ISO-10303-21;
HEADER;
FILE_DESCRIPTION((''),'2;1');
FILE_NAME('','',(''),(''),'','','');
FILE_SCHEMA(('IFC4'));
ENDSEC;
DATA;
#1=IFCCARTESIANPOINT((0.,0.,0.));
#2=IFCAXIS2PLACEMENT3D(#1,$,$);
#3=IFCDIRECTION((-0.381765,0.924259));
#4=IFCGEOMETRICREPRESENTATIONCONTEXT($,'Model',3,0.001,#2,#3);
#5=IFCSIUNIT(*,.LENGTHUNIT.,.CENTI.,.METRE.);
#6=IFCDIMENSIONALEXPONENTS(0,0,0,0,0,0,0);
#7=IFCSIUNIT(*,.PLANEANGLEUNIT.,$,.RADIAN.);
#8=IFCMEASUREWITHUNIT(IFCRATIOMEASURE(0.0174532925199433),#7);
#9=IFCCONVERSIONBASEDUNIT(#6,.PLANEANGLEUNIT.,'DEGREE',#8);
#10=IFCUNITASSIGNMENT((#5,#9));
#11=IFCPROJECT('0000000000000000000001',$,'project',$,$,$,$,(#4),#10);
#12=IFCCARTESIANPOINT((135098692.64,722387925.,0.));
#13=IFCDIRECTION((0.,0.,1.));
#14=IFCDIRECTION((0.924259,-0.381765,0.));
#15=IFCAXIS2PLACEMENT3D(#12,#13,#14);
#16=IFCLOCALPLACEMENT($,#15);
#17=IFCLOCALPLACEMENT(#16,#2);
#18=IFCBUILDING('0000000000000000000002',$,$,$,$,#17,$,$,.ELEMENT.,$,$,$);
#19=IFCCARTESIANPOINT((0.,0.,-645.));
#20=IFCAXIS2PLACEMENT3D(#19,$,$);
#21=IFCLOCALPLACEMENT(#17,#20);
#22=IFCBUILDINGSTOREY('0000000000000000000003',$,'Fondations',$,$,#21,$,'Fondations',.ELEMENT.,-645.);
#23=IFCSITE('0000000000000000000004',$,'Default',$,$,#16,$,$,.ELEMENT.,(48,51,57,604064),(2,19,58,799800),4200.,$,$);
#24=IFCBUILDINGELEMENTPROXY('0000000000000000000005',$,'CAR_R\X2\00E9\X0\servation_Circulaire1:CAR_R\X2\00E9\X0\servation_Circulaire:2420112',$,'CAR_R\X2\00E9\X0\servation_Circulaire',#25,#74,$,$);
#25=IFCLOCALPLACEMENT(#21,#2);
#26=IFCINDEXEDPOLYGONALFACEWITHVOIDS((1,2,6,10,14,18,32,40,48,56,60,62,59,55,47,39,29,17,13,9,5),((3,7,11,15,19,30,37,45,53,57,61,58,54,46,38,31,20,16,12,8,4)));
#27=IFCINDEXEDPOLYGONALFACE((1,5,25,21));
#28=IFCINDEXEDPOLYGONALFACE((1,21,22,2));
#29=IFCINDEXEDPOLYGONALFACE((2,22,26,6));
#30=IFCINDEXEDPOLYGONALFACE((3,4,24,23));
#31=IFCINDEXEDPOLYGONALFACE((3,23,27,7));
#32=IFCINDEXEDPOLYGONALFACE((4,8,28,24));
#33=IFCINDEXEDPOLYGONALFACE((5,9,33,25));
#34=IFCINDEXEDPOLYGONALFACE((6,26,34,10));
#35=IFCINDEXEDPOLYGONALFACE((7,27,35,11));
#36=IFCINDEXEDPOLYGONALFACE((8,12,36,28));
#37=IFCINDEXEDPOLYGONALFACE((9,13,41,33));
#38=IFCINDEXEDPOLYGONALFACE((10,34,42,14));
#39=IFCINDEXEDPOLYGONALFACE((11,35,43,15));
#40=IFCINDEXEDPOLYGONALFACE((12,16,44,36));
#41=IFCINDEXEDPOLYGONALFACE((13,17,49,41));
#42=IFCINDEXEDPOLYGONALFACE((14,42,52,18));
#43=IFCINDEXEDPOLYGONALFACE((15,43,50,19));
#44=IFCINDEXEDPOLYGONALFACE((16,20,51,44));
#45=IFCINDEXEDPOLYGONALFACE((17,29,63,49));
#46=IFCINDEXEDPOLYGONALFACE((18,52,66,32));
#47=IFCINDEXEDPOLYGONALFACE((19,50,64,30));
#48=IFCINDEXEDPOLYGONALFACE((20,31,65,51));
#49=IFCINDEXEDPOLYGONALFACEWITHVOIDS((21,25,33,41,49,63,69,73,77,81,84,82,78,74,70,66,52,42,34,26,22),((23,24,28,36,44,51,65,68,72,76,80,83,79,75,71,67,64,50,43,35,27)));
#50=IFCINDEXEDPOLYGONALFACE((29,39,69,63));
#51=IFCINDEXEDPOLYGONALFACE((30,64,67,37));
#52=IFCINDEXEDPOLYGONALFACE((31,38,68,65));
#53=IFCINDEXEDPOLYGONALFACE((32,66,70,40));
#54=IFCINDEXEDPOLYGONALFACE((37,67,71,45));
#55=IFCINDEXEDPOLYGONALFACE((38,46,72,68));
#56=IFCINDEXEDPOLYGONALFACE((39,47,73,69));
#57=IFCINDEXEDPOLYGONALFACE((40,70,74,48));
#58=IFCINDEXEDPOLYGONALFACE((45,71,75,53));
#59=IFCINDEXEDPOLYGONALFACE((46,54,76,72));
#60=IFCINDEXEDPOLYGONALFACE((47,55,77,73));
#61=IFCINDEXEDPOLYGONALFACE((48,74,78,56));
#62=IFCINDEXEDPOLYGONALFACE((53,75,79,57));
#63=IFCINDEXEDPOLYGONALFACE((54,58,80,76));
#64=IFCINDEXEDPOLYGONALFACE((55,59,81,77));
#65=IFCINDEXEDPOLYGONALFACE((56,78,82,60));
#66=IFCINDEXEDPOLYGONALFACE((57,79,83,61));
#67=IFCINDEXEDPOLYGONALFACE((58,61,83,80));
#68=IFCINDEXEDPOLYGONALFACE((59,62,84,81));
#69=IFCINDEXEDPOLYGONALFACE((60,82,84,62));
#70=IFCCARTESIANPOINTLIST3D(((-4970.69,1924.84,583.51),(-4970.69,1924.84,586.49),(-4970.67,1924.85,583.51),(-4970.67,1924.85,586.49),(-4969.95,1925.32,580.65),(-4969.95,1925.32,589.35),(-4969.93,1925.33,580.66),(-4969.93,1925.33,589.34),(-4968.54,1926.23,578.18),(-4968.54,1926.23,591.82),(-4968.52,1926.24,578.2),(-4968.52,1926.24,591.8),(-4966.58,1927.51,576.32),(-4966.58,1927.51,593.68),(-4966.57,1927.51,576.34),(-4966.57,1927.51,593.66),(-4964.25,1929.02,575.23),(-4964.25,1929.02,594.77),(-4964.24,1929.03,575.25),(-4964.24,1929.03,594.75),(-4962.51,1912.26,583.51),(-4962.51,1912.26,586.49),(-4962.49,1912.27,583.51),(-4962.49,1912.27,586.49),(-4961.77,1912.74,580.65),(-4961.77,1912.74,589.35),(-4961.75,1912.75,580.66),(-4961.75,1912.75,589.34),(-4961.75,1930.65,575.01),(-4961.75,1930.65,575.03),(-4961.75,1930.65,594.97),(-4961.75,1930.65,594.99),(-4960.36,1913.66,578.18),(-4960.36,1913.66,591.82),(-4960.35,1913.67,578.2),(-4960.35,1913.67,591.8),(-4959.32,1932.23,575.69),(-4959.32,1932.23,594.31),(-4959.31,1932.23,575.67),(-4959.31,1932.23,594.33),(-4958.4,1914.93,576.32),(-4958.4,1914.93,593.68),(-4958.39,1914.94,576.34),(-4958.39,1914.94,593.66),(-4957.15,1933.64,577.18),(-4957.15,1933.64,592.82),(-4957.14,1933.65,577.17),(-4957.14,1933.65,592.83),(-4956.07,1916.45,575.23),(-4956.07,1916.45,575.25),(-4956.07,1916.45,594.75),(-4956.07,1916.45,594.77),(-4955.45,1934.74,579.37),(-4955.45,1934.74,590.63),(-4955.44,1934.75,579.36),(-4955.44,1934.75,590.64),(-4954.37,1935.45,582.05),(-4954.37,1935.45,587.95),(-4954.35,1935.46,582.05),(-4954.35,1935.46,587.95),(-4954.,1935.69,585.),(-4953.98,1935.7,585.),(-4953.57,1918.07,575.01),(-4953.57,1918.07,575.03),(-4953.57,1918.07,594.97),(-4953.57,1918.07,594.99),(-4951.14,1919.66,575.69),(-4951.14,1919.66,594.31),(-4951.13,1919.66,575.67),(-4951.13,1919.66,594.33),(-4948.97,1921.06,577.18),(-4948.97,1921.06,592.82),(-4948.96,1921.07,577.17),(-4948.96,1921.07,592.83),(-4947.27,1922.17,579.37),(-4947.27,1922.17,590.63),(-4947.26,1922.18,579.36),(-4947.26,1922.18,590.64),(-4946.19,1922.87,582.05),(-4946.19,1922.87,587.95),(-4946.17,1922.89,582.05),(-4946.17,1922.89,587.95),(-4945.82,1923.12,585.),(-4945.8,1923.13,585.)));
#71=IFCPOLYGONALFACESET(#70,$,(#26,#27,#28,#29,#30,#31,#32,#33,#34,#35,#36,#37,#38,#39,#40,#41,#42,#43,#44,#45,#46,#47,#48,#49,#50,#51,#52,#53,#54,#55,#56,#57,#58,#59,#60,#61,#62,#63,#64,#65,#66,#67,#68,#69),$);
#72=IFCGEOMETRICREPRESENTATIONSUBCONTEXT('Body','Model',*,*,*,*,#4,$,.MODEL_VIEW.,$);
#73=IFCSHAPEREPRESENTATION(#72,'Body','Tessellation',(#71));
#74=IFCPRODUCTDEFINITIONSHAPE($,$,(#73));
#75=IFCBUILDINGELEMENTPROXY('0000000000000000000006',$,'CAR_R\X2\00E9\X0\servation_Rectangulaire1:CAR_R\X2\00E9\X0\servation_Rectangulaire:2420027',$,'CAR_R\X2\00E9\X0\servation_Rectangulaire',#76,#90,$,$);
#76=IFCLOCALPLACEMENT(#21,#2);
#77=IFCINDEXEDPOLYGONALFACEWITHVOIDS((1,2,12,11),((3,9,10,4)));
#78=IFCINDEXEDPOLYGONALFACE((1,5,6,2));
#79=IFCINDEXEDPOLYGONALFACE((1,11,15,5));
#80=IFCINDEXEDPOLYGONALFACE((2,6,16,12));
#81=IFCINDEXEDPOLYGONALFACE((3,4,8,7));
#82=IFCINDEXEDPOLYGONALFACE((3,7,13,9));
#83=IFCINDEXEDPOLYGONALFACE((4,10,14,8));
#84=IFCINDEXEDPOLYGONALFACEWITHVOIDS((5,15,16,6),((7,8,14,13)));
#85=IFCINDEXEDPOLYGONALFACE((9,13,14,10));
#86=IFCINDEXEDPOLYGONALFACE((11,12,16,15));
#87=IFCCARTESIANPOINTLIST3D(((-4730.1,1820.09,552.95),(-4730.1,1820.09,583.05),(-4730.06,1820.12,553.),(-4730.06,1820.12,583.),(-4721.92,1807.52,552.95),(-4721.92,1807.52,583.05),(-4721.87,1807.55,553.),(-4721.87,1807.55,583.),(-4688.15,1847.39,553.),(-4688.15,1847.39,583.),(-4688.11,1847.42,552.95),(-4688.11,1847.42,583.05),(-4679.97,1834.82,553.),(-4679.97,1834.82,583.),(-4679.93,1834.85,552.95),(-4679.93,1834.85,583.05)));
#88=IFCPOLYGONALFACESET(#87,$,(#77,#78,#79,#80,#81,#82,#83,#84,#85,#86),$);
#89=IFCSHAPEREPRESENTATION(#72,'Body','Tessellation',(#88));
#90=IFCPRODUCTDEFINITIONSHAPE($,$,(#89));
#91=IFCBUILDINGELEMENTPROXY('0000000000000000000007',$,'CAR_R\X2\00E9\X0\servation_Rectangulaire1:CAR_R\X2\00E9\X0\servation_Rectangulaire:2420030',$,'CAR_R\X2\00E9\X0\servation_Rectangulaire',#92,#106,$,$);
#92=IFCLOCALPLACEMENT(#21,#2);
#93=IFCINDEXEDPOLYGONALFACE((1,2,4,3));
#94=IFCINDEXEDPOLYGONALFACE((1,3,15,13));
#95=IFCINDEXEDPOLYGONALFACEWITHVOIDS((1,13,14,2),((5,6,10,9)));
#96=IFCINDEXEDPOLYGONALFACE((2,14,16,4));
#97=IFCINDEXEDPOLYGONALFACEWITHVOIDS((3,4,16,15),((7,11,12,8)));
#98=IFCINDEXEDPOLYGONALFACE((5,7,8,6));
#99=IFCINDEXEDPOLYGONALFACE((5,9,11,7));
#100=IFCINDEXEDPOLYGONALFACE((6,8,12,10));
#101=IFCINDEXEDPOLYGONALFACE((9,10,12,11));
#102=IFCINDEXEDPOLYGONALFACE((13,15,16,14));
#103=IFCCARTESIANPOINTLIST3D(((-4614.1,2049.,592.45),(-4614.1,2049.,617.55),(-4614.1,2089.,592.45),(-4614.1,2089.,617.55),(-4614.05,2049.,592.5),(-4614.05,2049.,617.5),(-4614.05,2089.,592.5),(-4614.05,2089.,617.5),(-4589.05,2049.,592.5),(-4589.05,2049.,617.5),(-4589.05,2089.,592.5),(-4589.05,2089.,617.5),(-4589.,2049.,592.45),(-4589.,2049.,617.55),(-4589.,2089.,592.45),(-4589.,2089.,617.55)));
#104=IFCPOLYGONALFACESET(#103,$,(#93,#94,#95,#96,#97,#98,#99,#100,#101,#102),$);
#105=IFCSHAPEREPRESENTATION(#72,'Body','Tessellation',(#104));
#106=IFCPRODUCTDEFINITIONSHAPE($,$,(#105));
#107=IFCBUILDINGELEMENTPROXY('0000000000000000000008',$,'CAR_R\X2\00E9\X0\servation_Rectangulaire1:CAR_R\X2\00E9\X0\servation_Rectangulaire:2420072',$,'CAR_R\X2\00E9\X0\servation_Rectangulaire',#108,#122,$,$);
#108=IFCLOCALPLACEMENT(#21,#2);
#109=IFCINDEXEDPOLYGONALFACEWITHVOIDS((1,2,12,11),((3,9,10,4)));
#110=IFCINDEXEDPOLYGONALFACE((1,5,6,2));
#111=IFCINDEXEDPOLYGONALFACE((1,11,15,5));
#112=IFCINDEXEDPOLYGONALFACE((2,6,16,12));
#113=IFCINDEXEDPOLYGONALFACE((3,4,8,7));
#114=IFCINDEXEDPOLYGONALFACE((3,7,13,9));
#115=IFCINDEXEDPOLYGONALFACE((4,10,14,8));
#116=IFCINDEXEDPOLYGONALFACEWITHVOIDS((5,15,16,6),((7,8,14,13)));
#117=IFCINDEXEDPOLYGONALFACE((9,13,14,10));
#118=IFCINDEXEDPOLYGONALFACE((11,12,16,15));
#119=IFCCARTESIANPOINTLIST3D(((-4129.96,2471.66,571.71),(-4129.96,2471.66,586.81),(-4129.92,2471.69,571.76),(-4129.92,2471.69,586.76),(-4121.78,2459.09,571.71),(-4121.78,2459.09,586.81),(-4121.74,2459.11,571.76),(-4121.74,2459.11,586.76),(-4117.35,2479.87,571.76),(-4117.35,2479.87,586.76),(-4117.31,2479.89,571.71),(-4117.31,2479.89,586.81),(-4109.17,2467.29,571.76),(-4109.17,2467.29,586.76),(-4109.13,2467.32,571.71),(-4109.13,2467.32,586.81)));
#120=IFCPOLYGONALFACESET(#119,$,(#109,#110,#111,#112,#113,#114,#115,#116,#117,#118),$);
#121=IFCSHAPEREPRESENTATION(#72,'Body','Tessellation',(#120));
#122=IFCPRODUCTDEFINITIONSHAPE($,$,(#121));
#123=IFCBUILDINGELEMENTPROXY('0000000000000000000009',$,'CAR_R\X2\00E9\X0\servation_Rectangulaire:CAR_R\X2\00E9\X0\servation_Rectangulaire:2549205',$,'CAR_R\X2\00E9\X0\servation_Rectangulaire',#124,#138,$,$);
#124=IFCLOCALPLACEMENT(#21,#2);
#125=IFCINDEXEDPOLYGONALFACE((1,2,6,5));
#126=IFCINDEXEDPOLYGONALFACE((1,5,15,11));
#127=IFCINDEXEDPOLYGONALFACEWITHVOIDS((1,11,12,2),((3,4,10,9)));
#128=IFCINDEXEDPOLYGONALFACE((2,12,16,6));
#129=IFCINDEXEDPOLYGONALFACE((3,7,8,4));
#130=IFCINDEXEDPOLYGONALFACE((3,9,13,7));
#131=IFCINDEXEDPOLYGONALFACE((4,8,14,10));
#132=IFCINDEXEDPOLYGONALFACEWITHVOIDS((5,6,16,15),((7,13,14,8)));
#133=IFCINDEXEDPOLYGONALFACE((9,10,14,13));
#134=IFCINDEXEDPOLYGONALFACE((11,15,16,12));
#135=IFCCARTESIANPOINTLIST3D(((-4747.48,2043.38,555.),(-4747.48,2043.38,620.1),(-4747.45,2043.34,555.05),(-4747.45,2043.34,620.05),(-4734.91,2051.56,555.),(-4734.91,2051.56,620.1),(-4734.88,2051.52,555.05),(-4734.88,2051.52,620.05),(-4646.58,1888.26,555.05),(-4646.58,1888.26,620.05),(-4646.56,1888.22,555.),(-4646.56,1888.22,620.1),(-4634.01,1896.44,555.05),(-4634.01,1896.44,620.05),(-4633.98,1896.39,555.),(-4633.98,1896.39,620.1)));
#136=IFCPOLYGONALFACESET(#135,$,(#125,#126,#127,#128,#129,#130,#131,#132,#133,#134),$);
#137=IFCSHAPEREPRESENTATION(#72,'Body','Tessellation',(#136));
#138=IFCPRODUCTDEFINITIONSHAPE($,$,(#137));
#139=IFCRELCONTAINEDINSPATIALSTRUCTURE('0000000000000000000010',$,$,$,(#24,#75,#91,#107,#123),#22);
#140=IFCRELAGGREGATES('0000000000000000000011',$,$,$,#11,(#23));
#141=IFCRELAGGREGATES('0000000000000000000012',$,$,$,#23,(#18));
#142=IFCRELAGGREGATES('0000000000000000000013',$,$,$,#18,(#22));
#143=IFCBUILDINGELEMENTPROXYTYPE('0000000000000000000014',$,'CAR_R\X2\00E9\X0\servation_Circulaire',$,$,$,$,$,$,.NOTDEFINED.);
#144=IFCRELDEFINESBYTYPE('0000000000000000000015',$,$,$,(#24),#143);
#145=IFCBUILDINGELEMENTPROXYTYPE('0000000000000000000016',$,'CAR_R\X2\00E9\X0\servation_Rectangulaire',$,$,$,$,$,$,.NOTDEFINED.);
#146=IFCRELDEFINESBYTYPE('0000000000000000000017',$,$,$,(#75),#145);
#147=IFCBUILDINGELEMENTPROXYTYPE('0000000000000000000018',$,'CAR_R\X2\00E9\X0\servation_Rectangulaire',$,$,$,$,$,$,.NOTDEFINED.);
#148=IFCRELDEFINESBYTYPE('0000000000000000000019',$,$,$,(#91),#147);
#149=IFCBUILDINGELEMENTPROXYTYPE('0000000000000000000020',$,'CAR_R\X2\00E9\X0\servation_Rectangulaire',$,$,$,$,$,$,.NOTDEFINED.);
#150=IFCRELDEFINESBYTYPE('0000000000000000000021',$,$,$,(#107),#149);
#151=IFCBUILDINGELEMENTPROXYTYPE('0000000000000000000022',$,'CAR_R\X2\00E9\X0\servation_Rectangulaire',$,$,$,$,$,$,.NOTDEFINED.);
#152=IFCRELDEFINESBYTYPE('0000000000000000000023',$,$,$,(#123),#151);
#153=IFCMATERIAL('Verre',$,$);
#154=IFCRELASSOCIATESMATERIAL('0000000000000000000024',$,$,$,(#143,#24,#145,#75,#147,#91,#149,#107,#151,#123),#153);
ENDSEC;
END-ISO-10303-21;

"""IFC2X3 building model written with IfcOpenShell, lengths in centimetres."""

from ifc_helpers import new_model, entity, si_unit, converted_unit, direction, frame, frame_2d, origin, place, context, subcontext, project, spatial, polyline, hollow_circle, outline, extrude, source, transform, mapped, material, type_object, type_shapes, element, save


model = new_model("IFC2X3")

# Units and contexts
model_context = context("Model", 3, precision=0.001, world=origin(), true_north=direction((-0.381765, 0.924259)))
body_context = subcontext(model_context, "Body", "Model", "MODEL_VIEW")
ifc_project = project(units=[si_unit("LENGTHUNIT", "METRE", prefix="CENTI"), converted_unit("PLANEANGLEUNIT", "DEGREE", entity("IfcRatioMeasure", 0.0174532925199433), si_unit("PLANEANGLEUNIT", "RADIAN"), dimensions=[0, 0, 0, 0, 0, 0, 0])], contexts=[model_context])

# Site, building, storey
site_placement = place(None, frame((135098692.64, 722387925.0, 0.0), z_axis=(0.0, 0.0, 1.0), x_axis=(0.924259, -0.381765, 0.0)))
site = spatial("IfcSite", under=ifc_project, at=site_placement, Name="Default", CompositionType="ELEMENT", RefLatitude=(48, 51, 57, 604064), RefLongitude=(2, 19, 58, 799800), RefElevation=4200.0)
building_placement = place(site_placement, origin())
building = spatial("IfcBuilding", under=site, at=building_placement, CompositionType="ELEMENT")
storey_placement = place(building_placement, frame((0.0, 0.0, -645.0)))
storey = spatial("IfcBuildingStorey", under=building, at=storey_placement, Name="Fondations", LongName="Fondations", CompositionType="ELEMENT", Elevation=-645.0)

# Building element proxies
ifc_material_1 = material(Name="Verre")
building_element_proxy_type_1 = type_object("IfcBuildingElementProxyType", Name="CAR_Réservation_Circulaire", PredefinedType="NOTDEFINED", material=ifc_material_1)
shared_shape_1 = source(origin(), body_context, "Body", "SweptSolid", [
    extrude(hollow_circle(Radius=10.02, WallThickness=0.02, at=frame_2d((0.0, 0.0), x_axis=(1.0, 0.0))), frame((0.0, 0.0, -15.0)), (0.0, 0.0, 1.0), 15.0),
])
type_shapes(building_element_proxy_type_1, [shared_shape_1])
for number, where, z_axis, x_axis, name in (
    (1, (-4954.2, 1917.66, 585.0), (0.545236, -0.838282, 0.0), (0.838282, 0.545236, 0.0), "CAR_Réservation_Circulaire1:CAR_Réservation_Circulaire:2420112"),
):
    element("IfcBuildingElementProxy", number, at=place(storey_placement, frame(where, z_axis=z_axis, x_axis=x_axis)), inside=storey, type_object=building_element_proxy_type_1, material=ifc_material_1, Name=name, ObjectType="CAR_Réservation_Circulaire", context=body_context, shape_type="MappedRepresentation", body=[
        mapped(shared_shape_1, transform((0.0, 0.0, 0.0), scale=1.0)),
    ])
building_element_proxy_type_2 = type_object("IfcBuildingElementProxyType", Name="CAR_Réservation_Rectangulaire", PredefinedType="NOTDEFINED", material=ifc_material_1)
shared_shape_2 = source(origin(), body_context, "Body", "SweptSolid", [
    extrude(outline(polyline([(-25.05, -15.05), (25.05, -15.05), (25.05, 15.05), (-25.05, 15.05), (-25.05, -15.05)]), holes=[polyline([(25.0, -15.0), (-25.0, -15.0), (-25.0, 15.0), (25.0, 15.0), (25.0, -15.0)])]), frame((0.0, 0.0, -15.0), z_axis=(0.0, 0.0, 1.0), x_axis=(-1.0, 0.0, 0.0)), (0.0, 0.0, 1.0), 15.0),
])
type_shapes(building_element_proxy_type_2, [shared_shape_2])
proxy_1_placement = place(storey_placement, frame((-4700.92, 1821.18, 568.0), z_axis=(0.545548, -0.83808, 0.0), x_axis=(0.83808, 0.545548, 0.0)))
element("IfcBuildingElementProxy", 2, at=proxy_1_placement, inside=storey, type_object=building_element_proxy_type_2, material=ifc_material_1, Name="CAR_Réservation_Rectangulaire1:CAR_Réservation_Rectangulaire:2420027", ObjectType="CAR_Réservation_Rectangulaire", context=body_context, shape_type="MappedRepresentation", body=[
    mapped(shared_shape_2, transform((0.0, 0.0, 0.0), scale=1.0)),
])
building_element_proxy_type_3 = type_object("IfcBuildingElementProxyType", Name="CAR_Réservation_Rectangulaire", PredefinedType="NOTDEFINED", material=ifc_material_1)
shared_shape_3 = source(origin(), body_context, "Body", "SweptSolid", [
    extrude(outline(polyline([(-12.55, -12.55), (12.55, -12.55), (12.55, 12.55), (-12.55, 12.55), (-12.55, -12.55)]), holes=[polyline([(12.5, -12.5), (-12.5, -12.5), (-12.5, 12.5), (12.5, 12.5), (12.5, -12.5)])]), frame((0.0, 0.0, 0.0), z_axis=(0.0, 0.0, 1.0), x_axis=(-1.0, 0.0, 0.0)), (0.0, 0.0, 1.0), 40.0),
])
type_shapes(building_element_proxy_type_3, [shared_shape_3])
proxy_2_placement = place(storey_placement, frame((-4601.55, 2089.0, 605.0), z_axis=(0.0, -1.0, 0.0), x_axis=(1.0, 0.0, 0.0)))
element("IfcBuildingElementProxy", 3, at=proxy_2_placement, inside=storey, type_object=building_element_proxy_type_3, material=ifc_material_1, Name="CAR_Réservation_Rectangulaire1:CAR_Réservation_Rectangulaire:2420030", ObjectType="CAR_Réservation_Rectangulaire", context=body_context, shape_type="MappedRepresentation", body=[
    mapped(shared_shape_3, transform((0.0, 0.0, 0.0), scale=1.0)),
])
building_element_proxy_type_4 = type_object("IfcBuildingElementProxyType", Name="CAR_Réservation_Rectangulaire", PredefinedType="NOTDEFINED", material=ifc_material_1)
shared_shape_4 = source(origin(), body_context, "Body", "SweptSolid", [
    extrude(outline(polyline([(-7.55, -7.55), (7.55, -7.55), (7.55, 7.55), (-7.55, 7.55), (-7.55, -7.55)]), holes=[polyline([(7.5, -7.5), (-7.5, -7.5), (-7.5, 7.5), (7.5, 7.5), (7.5, -7.5)])]), frame((0.0, 0.0, -15.0), z_axis=(0.0, 0.0, 1.0), x_axis=(-1.0, 0.0, 0.0)), (0.0, 0.0, 1.0), 15.0),
])
type_shapes(building_element_proxy_type_4, [shared_shape_4])
proxy_3_placement = place(storey_placement, frame((-4123.63, 2475.78, 579.26), z_axis=(-0.545236, 0.838282, 0.0), x_axis=(-0.838282, -0.545236, 0.0)))
element("IfcBuildingElementProxy", 4, at=proxy_3_placement, inside=storey, type_object=building_element_proxy_type_4, material=ifc_material_1, Name="CAR_Réservation_Rectangulaire1:CAR_Réservation_Rectangulaire:2420072", ObjectType="CAR_Réservation_Rectangulaire", context=body_context, shape_type="MappedRepresentation", body=[
    mapped(shared_shape_4, transform((0.0, 0.0, 0.0), scale=1.0)),
])
building_element_proxy_type_5 = type_object("IfcBuildingElementProxyType", Name="CAR_Réservation_Rectangulaire", PredefinedType="NOTDEFINED", material=ifc_material_1)
shared_shape_5 = source(origin(), body_context, "Body", "SweptSolid", [
    extrude(outline(polyline([(-92.55, -32.55), (92.55, -32.55), (92.55, 32.55), (-92.55, 32.55), (-92.55, -32.55)]), holes=[polyline([(92.5, -32.5), (-92.5, -32.5), (-92.5, 32.5), (92.5, 32.5), (92.5, -32.5)])]), frame((0.0, 0.0, -15.0), z_axis=(0.0, 0.0, 1.0), x_axis=(-1.0, 0.0, 0.0)), (0.0, 0.0, 1.0), 15.0),
])
type_shapes(building_element_proxy_type_5, [shared_shape_5])
proxy_4_placement = place(storey_placement, frame((-4697.02, 1965.8, 587.55), z_axis=(-0.838282, -0.545236, 0.0), x_axis=(0.545236, -0.838282, 0.0)))
element("IfcBuildingElementProxy", 5, at=proxy_4_placement, inside=storey, type_object=building_element_proxy_type_5, material=ifc_material_1, Name="CAR_Réservation_Rectangulaire:CAR_Réservation_Rectangulaire:2549205", ObjectType="CAR_Réservation_Rectangulaire", context=body_context, shape_type="MappedRepresentation", body=[
    mapped(shared_shape_5, transform((0.0, 0.0, 0.0), scale=1.0)),
])

save(model, "model.ifc")
